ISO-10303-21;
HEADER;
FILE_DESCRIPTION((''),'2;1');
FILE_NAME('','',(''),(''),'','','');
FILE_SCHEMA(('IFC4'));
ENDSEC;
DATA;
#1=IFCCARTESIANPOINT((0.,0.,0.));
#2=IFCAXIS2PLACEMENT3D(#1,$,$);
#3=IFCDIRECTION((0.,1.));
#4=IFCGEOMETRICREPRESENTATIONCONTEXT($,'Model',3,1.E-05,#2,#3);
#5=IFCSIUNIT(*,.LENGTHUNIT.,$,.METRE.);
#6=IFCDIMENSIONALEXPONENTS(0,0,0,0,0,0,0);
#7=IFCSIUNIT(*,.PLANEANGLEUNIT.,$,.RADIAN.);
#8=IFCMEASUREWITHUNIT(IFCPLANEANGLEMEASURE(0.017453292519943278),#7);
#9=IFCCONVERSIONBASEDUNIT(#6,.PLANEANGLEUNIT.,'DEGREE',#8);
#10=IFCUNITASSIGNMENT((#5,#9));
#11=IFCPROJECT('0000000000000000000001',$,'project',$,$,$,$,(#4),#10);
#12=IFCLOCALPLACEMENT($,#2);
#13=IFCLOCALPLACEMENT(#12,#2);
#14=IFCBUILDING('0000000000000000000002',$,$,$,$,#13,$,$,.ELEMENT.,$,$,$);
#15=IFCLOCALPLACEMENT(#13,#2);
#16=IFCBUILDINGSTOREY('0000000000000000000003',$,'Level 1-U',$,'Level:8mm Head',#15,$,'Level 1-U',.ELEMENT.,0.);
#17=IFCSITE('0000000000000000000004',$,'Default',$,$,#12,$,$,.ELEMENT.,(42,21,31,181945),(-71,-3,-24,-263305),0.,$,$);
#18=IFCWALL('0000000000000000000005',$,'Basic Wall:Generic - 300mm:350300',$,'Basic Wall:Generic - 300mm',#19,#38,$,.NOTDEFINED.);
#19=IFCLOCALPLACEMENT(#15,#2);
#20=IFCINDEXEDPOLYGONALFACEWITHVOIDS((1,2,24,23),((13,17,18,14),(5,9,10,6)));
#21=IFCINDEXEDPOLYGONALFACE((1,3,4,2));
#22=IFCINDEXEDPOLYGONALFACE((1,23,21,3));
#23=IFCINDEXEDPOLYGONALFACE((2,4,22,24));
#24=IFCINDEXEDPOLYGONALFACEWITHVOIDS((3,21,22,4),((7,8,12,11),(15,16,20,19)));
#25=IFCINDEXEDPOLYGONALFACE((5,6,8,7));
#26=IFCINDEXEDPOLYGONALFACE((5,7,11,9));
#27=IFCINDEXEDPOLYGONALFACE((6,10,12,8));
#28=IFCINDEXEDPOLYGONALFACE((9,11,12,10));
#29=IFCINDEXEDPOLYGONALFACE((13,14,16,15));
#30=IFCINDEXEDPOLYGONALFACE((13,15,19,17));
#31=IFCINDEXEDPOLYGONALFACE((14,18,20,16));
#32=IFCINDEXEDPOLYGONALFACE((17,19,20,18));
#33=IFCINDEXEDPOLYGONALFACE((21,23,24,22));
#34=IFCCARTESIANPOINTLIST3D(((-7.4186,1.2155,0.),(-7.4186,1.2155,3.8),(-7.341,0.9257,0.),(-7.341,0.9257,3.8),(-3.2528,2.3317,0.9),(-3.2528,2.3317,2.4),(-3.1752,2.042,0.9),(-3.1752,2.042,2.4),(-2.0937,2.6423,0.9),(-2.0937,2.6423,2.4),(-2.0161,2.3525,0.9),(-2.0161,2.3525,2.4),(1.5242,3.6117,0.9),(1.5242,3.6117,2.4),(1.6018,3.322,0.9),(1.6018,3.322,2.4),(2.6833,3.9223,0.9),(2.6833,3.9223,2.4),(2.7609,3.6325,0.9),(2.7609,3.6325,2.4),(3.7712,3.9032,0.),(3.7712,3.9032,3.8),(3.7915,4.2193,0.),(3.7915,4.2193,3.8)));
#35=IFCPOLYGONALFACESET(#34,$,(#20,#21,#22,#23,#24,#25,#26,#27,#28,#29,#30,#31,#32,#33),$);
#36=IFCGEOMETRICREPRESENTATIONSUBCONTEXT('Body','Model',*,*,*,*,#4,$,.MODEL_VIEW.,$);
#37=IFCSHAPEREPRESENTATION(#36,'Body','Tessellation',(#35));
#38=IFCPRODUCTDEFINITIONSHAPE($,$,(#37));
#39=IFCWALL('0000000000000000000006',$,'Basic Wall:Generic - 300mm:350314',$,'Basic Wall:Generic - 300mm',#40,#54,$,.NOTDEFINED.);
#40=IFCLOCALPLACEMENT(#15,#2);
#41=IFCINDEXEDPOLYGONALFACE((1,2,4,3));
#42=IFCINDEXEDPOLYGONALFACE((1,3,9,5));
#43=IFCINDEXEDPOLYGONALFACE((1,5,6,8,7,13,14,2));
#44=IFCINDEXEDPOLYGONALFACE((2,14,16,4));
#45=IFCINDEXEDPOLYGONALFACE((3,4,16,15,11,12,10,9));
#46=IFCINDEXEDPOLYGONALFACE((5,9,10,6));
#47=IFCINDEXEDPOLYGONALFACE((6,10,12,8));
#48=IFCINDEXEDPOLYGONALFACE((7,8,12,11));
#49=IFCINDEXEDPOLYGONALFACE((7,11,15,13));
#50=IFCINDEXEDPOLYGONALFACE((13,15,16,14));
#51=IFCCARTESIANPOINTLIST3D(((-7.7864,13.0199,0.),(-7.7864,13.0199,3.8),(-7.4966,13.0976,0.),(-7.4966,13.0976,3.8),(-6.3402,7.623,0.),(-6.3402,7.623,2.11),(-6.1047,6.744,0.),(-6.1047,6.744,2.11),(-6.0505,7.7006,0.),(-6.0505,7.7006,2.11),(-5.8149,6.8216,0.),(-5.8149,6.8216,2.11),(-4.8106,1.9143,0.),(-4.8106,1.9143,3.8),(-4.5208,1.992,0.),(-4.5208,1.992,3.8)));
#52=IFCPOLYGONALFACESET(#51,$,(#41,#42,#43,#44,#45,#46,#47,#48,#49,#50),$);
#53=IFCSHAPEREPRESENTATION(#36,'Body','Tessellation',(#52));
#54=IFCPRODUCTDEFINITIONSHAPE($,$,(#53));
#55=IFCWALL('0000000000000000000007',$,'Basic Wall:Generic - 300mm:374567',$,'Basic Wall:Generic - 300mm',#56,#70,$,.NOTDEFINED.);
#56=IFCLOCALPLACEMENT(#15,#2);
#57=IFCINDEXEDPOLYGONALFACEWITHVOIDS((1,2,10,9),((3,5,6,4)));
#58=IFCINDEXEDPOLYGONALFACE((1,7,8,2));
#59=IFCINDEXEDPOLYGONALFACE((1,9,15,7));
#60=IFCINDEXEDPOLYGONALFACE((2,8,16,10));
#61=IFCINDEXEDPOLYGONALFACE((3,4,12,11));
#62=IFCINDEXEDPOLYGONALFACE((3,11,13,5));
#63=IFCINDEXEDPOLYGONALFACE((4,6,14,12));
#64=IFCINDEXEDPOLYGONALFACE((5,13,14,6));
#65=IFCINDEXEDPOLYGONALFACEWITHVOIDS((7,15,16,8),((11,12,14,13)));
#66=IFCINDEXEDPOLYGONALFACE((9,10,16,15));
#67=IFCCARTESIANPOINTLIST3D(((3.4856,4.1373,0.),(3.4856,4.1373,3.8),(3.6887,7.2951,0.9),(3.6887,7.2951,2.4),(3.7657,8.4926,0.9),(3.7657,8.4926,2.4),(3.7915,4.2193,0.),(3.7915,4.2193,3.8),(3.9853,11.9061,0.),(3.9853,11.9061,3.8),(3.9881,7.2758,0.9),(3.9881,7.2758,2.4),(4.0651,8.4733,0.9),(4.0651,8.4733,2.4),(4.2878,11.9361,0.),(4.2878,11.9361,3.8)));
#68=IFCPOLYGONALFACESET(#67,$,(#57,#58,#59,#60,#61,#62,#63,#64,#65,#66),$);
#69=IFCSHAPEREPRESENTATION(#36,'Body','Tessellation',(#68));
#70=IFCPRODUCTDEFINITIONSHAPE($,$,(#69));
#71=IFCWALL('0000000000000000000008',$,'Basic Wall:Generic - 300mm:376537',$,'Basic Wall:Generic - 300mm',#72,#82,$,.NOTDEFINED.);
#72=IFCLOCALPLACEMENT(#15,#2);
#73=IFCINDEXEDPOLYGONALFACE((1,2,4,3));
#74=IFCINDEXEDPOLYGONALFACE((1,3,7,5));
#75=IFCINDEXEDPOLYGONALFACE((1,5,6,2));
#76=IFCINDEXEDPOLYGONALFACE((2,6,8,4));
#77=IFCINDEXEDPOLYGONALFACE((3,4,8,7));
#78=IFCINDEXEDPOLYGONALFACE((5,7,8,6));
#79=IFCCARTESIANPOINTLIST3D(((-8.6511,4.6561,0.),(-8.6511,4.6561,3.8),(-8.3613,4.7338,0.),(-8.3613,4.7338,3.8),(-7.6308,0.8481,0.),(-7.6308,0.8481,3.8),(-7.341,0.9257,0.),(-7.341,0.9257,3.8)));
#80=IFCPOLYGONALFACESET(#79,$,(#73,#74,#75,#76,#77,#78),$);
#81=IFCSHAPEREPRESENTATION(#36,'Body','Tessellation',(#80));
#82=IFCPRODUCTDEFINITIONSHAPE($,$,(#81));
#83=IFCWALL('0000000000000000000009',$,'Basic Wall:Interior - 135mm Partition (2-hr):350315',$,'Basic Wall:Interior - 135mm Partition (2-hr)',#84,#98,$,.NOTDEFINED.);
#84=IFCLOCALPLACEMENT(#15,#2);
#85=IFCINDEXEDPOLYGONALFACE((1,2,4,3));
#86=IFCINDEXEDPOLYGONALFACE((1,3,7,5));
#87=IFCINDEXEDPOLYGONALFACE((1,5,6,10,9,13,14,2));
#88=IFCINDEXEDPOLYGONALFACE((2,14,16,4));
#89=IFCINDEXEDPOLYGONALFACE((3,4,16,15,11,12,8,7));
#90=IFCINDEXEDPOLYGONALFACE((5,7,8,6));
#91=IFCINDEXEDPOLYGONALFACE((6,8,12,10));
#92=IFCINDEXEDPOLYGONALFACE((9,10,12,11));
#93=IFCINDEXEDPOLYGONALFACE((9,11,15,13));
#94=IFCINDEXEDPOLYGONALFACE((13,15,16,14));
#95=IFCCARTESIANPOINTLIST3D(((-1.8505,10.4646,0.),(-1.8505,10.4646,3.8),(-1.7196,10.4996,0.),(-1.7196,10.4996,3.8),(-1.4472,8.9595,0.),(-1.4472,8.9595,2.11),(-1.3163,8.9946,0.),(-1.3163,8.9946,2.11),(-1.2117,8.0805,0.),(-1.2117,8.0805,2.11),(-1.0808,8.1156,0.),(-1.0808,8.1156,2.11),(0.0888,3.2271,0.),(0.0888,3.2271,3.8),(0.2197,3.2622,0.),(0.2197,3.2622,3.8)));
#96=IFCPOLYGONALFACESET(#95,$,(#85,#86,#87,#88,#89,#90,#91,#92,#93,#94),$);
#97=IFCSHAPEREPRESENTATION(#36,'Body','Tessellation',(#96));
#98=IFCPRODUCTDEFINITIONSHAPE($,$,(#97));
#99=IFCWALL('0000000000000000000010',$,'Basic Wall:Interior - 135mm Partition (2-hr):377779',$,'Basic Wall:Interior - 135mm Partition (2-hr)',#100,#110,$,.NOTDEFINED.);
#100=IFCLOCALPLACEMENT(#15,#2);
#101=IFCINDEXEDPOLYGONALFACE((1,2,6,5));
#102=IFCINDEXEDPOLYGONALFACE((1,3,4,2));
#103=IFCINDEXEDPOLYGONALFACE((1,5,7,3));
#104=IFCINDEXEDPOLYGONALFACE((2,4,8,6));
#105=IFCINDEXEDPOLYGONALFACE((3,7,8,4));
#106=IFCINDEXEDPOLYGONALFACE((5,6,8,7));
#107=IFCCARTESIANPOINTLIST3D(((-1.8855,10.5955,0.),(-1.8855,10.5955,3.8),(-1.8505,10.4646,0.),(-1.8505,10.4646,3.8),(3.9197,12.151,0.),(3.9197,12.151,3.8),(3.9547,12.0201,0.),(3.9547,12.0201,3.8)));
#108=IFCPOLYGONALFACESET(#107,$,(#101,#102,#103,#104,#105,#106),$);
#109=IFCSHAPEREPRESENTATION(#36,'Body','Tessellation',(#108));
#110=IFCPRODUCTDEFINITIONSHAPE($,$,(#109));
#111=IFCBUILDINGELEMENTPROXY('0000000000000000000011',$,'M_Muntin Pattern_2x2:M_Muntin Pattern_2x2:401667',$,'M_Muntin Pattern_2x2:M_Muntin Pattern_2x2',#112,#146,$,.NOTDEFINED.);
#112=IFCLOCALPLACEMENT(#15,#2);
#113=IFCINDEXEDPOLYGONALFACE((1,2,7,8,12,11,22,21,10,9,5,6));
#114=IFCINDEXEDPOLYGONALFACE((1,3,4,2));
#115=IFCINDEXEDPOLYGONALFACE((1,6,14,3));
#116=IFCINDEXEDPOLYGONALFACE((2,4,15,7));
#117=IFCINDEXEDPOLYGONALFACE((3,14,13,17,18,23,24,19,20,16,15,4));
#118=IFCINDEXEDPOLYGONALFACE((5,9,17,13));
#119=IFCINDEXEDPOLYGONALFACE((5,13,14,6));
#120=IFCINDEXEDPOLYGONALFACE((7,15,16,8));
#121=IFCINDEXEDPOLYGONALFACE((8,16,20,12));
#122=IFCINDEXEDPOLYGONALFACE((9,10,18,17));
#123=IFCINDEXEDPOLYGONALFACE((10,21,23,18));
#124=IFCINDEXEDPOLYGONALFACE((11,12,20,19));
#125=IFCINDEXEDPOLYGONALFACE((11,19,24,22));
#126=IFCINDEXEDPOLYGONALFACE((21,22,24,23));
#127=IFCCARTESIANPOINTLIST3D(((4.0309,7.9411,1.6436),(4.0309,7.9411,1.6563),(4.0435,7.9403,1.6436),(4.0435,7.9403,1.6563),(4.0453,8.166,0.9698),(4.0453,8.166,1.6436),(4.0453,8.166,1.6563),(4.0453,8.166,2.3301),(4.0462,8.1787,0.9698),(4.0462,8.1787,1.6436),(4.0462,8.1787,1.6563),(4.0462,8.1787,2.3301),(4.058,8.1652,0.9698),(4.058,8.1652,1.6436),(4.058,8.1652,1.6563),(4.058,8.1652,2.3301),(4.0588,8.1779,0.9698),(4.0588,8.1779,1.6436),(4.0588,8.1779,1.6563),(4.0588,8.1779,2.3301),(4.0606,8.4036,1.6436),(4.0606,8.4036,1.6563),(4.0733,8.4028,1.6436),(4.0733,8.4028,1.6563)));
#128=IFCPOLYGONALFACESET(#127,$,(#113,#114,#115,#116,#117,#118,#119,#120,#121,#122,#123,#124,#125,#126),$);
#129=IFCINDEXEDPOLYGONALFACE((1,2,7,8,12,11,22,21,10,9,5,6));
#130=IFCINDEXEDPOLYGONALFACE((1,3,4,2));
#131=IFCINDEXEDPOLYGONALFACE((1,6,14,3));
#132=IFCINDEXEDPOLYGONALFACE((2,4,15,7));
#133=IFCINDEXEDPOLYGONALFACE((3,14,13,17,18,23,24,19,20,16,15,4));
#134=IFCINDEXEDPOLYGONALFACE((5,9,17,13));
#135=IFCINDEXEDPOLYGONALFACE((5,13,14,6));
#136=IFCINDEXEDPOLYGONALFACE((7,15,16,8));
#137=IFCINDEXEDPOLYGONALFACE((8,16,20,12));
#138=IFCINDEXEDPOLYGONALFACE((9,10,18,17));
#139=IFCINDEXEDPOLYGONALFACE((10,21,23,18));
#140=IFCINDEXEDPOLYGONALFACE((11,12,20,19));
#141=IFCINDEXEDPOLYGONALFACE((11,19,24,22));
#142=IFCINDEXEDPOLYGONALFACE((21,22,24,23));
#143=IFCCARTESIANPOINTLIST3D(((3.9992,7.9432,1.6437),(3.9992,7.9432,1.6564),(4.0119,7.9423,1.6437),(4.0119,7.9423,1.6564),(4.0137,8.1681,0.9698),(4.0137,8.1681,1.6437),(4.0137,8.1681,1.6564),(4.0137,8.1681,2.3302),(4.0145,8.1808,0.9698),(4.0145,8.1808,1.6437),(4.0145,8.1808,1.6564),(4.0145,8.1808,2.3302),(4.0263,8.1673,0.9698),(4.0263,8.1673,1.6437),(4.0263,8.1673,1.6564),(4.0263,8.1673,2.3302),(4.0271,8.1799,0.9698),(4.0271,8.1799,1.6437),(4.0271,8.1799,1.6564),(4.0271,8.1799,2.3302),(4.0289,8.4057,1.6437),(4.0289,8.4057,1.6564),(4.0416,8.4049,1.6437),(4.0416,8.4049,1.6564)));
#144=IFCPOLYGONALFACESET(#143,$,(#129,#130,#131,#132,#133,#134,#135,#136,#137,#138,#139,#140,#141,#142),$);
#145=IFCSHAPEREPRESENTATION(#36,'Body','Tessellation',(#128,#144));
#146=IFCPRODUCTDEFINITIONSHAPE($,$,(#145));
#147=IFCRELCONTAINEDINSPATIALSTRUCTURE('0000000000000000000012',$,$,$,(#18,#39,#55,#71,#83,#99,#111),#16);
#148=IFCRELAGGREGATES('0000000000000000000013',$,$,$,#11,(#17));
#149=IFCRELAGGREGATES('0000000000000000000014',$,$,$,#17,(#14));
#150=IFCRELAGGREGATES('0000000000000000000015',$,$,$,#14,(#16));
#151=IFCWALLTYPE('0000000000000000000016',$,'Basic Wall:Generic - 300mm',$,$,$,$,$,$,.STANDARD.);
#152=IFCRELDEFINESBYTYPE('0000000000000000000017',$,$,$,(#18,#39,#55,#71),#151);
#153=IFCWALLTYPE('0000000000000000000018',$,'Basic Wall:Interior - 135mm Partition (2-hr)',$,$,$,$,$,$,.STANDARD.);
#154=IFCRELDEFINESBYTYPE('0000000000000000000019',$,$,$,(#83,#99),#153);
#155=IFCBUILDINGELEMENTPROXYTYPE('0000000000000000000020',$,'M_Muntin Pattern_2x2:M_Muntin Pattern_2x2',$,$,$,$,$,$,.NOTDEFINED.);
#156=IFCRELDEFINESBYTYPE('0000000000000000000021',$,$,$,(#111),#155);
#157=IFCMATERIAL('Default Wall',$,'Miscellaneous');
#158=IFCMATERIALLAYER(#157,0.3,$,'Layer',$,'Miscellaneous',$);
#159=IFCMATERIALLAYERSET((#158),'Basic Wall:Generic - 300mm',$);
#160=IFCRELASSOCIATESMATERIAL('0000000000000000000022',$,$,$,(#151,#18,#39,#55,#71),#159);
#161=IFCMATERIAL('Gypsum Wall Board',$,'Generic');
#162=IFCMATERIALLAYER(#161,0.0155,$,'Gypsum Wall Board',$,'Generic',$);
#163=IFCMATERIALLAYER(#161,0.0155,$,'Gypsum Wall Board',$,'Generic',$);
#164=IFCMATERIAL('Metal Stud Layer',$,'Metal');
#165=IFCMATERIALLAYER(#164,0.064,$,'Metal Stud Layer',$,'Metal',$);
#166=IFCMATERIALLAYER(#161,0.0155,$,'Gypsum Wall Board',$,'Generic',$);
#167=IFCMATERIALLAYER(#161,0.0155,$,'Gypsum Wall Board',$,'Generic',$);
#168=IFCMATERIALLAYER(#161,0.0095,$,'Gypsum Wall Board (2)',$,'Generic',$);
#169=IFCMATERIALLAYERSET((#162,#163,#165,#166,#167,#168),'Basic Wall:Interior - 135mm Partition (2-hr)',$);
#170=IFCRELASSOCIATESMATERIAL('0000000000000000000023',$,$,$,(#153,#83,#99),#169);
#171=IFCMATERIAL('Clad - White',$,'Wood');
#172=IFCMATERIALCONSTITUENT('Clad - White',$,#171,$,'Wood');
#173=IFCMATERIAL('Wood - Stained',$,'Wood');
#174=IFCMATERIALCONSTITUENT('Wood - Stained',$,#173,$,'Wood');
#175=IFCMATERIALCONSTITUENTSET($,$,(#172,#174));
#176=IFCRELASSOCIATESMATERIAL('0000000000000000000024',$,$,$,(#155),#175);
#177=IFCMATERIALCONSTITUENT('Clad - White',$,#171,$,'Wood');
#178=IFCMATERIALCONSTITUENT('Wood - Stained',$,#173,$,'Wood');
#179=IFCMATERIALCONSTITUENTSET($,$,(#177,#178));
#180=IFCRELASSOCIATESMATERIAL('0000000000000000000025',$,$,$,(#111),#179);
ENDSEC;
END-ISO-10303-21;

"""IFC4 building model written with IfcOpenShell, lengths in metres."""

from ifc_helpers import new_model, entity, si_unit, converted_unit, direction, frame, frame_2d, origin, place, context, subcontext, project, spatial, polyline, rectangle, outline, extrude, source, transform, mapped, material, layer, layer_set, layer_usage, constituent, constituent_set, type_object, type_shapes, element, save


model = new_model("IFC4")

# Units and contexts
model_context = context("Model", 3, precision=1e-05, world=origin(), true_north=direction((0.0, 1.0)))
body_context = subcontext(model_context, "Body", "Model", "MODEL_VIEW")
ifc_project = project(units=[si_unit("LENGTHUNIT", "METRE"), converted_unit("PLANEANGLEUNIT", "DEGREE", entity("IfcPlaneAngleMeasure", 0.017453292519943278), si_unit("PLANEANGLEUNIT", "RADIAN"), dimensions=[0, 0, 0, 0, 0, 0, 0])], contexts=[model_context])

# Site, building, storey
site_placement = place(None, origin())
site = spatial("IfcSite", under=ifc_project, at=site_placement, Name="Default", CompositionType="ELEMENT", RefLatitude=(42, 21, 31, 181945), RefLongitude=(-71, -3, -24, -263305), RefElevation=0.0)
building_placement = place(site_placement, origin())
building = spatial("IfcBuilding", under=site, at=building_placement, CompositionType="ELEMENT")
storey_placement = place(building_placement, origin())
storey = spatial("IfcBuildingStorey", under=building, at=storey_placement, Name="Level 1-U", ObjectType="Level:8mm Head", LongName="Level 1-U", CompositionType="ELEMENT", Elevation=0.0)

# Wall, openings
ifc_material_1 = material(Name="Default Wall", Category="Miscellaneous")
ifc_layer_1 = layer(ifc_material_1, 0.3, Name="Layer", Category="Miscellaneous")
ifc_layer_set_1 = layer_set([ifc_layer_1], Name="Basic Wall:Generic - 300mm")
ifc_layer_usage_1 = layer_usage(ifc_layer_set_1, "AXIS2", "NEGATIVE", 0.15)
wall_type_1 = type_object("IfcWallType", Name="Basic Wall:Generic - 300mm", PredefinedType="STANDARD", material=ifc_layer_set_1)
wall_1_placement = place(storey_placement, frame((3.8303, 4.0744, 0.0), z_axis=(0.0, 0.0, 1.0), x_axis=(-0.965926, -0.258819, 0.0)))
wall_1 = element("IfcWall", 1, at=wall_1_placement, inside=storey, type_object=wall_type_1, material=ifc_layer_usage_1, Name="Basic Wall:Generic - 300mm:350300", ObjectType="Basic Wall:Generic - 300mm", PredefinedType="NOTDEFINED", context=body_context, shape_type="SweptSolid", body=[
    extrude(outline(polyline([(11.6056, -0.15), (11.6056, 0.15), (0.1014, 0.15), (0.0, -0.15), (0.3167, -0.15), (8.6056, -0.15), (8.9056, -0.15), (11.6056, -0.15)])), origin(), (0.0, 0.0, 1.0), 3.8),
])
opening_1_placement = place(wall_1_placement, frame((6.0928, -0.15, 0.9)))
element("IfcOpeningElement", 2, at=opening_1_placement, cuts=wall_1, PredefinedType="OPENING", context=body_context, shape_type="SweptSolid", body=[
    extrude(rectangle(XDim=1.5, YDim=1.2, at=frame_2d((0.75, 0.6), x_axis=(-1.0, 0.0))), frame((0.0, 0.0, 0.0), z_axis=(0.0, 1.0, 0.0), x_axis=(0.0, 0.0, 1.0)), (0.0, 0.0, 1.0), 0.3),
])
opening_2_placement = place(wall_1_placement, frame((1.1473, -0.15, 0.9)))
element("IfcOpeningElement", 3, at=opening_2_placement, cuts=wall_1, PredefinedType="OPENING", context=body_context, shape_type="SweptSolid", body=[
    extrude(rectangle(XDim=1.5, YDim=1.2, at=frame_2d((0.75, 0.6), x_axis=(-1.0, 0.0))), frame((0.0, 0.0, 0.0), z_axis=(0.0, 1.0, 0.0), x_axis=(0.0, 0.0, 1.0)), (0.0, 0.0, 1.0), 0.3),
])

# Walls, openings
wall_2_placement = place(storey_placement, frame((-7.6415, 13.0588, 0.0), z_axis=(0.0, 0.0, 1.0), x_axis=(0.258819, -0.965926, 0.0)))
wall_2 = element("IfcWall", 4, at=wall_2_placement, inside=storey, type_object=wall_type_1, material=ifc_layer_usage_1, Name="Basic Wall:Generic - 300mm:350314", ObjectType="Basic Wall:Generic - 300mm", PredefinedType="NOTDEFINED", context=body_context, shape_type="SweptSolid", body=[
    extrude(rectangle(XDim=11.4974, YDim=0.3, at=frame_2d((5.7487, 0.0), x_axis=(1.0, 0.0))), origin(), (0.0, 0.0, 1.0), 3.8),
])
opening_3_placement = place(wall_2_placement, frame((5.5874, -0.15, 0.0)))
element("IfcOpeningElement", 5, at=opening_3_placement, cuts=wall_2, PredefinedType="OPENING", context=body_context, shape_type="SweptSolid", body=[
    extrude(rectangle(XDim=2.11, YDim=0.91, at=frame_2d((1.055, 0.455), x_axis=(1.0, 0.0))), frame((0.0, 0.0, 0.0), z_axis=(0.0, 1.0, 0.0), x_axis=(0.0, 0.0, 1.0)), (0.0, 0.0, 1.0), 0.3),
])
wall_3_placement = place(storey_placement, frame((4.1381, 11.9457, 0.0), z_axis=(0.0, 0.0, 1.0), x_axis=(-0.064186, -0.997938, 0.0)))
wall_3 = element("IfcWall", 6, at=wall_3_placement, inside=storey, type_object=wall_type_1, material=ifc_layer_usage_1, Name="Basic Wall:Generic - 300mm:374567", ObjectType="Basic Wall:Generic - 300mm", PredefinedType="NOTDEFINED", context=body_context, shape_type="SweptSolid", body=[
    extrude(outline(polyline([(7.8342, -0.15), (7.7328, 0.15), (0.0, 0.15), (0.0493, -0.15), (7.8342, -0.15)])), origin(), (0.0, 0.0, 1.0), 3.8),
])
opening_4_placement = place(wall_3_placement, frame((3.4699, -0.15, 0.9)))
element("IfcOpeningElement", 7, at=opening_4_placement, cuts=wall_3, PredefinedType="OPENING", context=body_context, shape_type="SweptSolid", body=[
    extrude(rectangle(XDim=1.5, YDim=1.2, at=frame_2d((0.75, 0.6), x_axis=(-1.0, 0.0))), frame((0.0, 0.0, 0.0), z_axis=(0.0, 1.0, 0.0), x_axis=(0.0, 0.0, 1.0)), (0.0, 0.0, 1.0), 0.3),
])

# Wall
wall_4_placement = place(storey_placement, frame((-8.5062, 4.6949, 0.0), z_axis=(0.0, 0.0, 1.0), x_axis=(0.258819, -0.965926, 0.0)))
element("IfcWall", 8, at=wall_4_placement, inside=storey, type_object=wall_type_1, material=ifc_layer_usage_1, Name="Basic Wall:Generic - 300mm:376537", ObjectType="Basic Wall:Generic - 300mm", PredefinedType="NOTDEFINED", context=body_context, shape_type="SweptSolid", body=[
    extrude(rectangle(XDim=3.9424, YDim=0.3, at=frame_2d((1.9712, 0.0), x_axis=(-1.0, 0.0))), origin(), (0.0, 0.0, 1.0), 3.8),
])

# Wall, opening
ifc_material_2 = material(Name="Gypsum Wall Board", Category="Generic")
ifc_layer_2 = layer(ifc_material_2, 0.0155, Name="Gypsum Wall Board", Category="Generic")
ifc_layer_3 = layer(ifc_material_2, 0.0155, Name="Gypsum Wall Board", Category="Generic")
ifc_material_3 = material(Name="Metal Stud Layer", Category="Metal")
ifc_layer_4 = layer(ifc_material_3, 0.064, Name="Metal Stud Layer", Category="Metal")
ifc_layer_5 = layer(ifc_material_2, 0.0155, Name="Gypsum Wall Board", Category="Generic")
ifc_layer_6 = layer(ifc_material_2, 0.0155, Name="Gypsum Wall Board", Category="Generic")
ifc_layer_7 = layer(ifc_material_2, 0.0095, Name="Gypsum Wall Board (2)", Category="Generic")
ifc_layer_set_2 = layer_set([ifc_layer_2, ifc_layer_3, ifc_layer_4, ifc_layer_5, ifc_layer_6, ifc_layer_7], Name="Basic Wall:Interior - 135mm Partition (2-hr)")
ifc_layer_usage_2 = layer_usage(ifc_layer_set_2, "AXIS2", "NEGATIVE", 0.0677)
wall_type_2 = type_object("IfcWallType", Name="Basic Wall:Interior - 135mm Partition (2-hr)", PredefinedType="STANDARD", material=ifc_layer_set_2)
wall_5_placement = place(storey_placement, frame((-1.785, 10.4821, 0.0), z_axis=(0.0, 0.0, 1.0), x_axis=(0.258819, -0.965926, 0.0)))
wall_5 = element("IfcWall", 9, at=wall_5_placement, inside=storey, type_object=wall_type_2, material=ifc_layer_usage_2, Name="Basic Wall:Interior - 135mm Partition (2-hr):350315", ObjectType="Basic Wall:Interior - 135mm Partition (2-hr)", PredefinedType="NOTDEFINED", context=body_context, shape_type="SweptSolid", body=[
    extrude(rectangle(XDim=7.4928, YDim=0.1355, at=frame_2d((3.7464, 0.0), x_axis=(-1.0, 0.0))), origin(), (0.0, 0.0, 1.0), 3.8),
])
opening_5_placement = place(wall_5_placement, frame((2.4681, 0.0677, 0.0)))
element("IfcOpeningElement", 10, at=opening_5_placement, cuts=wall_5, PredefinedType="OPENING", context=body_context, shape_type="SweptSolid", body=[
    extrude(rectangle(XDim=2.11, YDim=0.91, at=frame_2d((1.055, 0.455), x_axis=(1.0, 0.0))), frame((0.0, 0.0, 0.0), z_axis=(0.0, -1.0, 0.0), x_axis=(0.0, 0.0, 1.0)), (0.0, 0.0, 1.0), 0.1355),
])

# Wall
wall_6_placement = place(storey_placement, frame((-1.868, 10.53, 0.0), z_axis=(0.0, 0.0, 1.0), x_axis=(0.965926, 0.258819, 0.0)))
element("IfcWall", 11, at=wall_6_placement, inside=storey, type_object=wall_type_2, material=ifc_layer_usage_2, Name="Basic Wall:Interior - 135mm Partition (2-hr):377779", ObjectType="Basic Wall:Interior - 135mm Partition (2-hr)", PredefinedType="NOTDEFINED", context=body_context, shape_type="SweptSolid", body=[
    extrude(rectangle(XDim=6.01, YDim=0.1355, at=frame_2d((3.005, 0.0), x_axis=(-1.0, 0.0))), origin(), (0.0, 0.0, 1.0), 3.8),
])

# Building element proxy
ifc_material_4 = material(Name="Clad - White", Category="Wood")
ifc_constituent_1 = constituent(ifc_material_4, Name="Clad - White", Category="Wood")
ifc_material_5 = material(Name="Wood - Stained", Category="Wood")
ifc_constituent_2 = constituent(ifc_material_5, Name="Wood - Stained", Category="Wood")
ifc_constituent_set_1 = constituent_set(constituents=[ifc_constituent_1, ifc_constituent_2])
ifc_constituent_3 = constituent(ifc_material_4, Name="Clad - White", Category="Wood")
ifc_constituent_4 = constituent(ifc_material_5, Name="Wood - Stained", Category="Wood")
ifc_constituent_set_2 = constituent_set(constituents=[ifc_constituent_3, ifc_constituent_4])
building_element_proxy_type_1 = type_object("IfcBuildingElementProxyType", Name="M_Muntin Pattern_2x2:M_Muntin Pattern_2x2", PredefinedType="NOTDEFINED", material=ifc_constituent_set_2)
shared_shape_1 = source(origin(), body_context, "Body", "SweptSolid", [
    extrude(outline(polyline([(0.0064, -0.0064), (0.6801, -0.0064), (0.6801, 0.0063), (0.0064, 0.0063), (0.0064, 0.2317), (-0.0063, 0.2317), (-0.0063, 0.0063), (-0.6802, 0.0063), (-0.6802, -0.0064), (-0.0063, -0.0064), (-0.0063, -0.2317), (0.0064, -0.2317), (0.0064, -0.0064)])), frame((0.0, 0.0095, 0.6801), z_axis=(0.0, 1.0, 0.0), x_axis=(0.0, 0.0, 1.0)), (0.0, 0.0, 1.0), 0.0127),
    extrude(outline(polyline([(0.0064, -0.0064), (0.6802, -0.0064), (0.6802, 0.0063), (0.0064, 0.0063), (0.0064, 0.2317), (-0.0063, 0.2317), (-0.0063, 0.0063), (-0.6802, 0.0063), (-0.6802, -0.0064), (-0.0063, -0.0064), (-0.0063, -0.2317), (0.0064, -0.2317), (0.0064, -0.0064)])), frame((0.0, -0.0222, 0.6802), z_axis=(0.0, 1.0, 0.0), x_axis=(0.0, 0.0, 1.0)), (0.0, 0.0, 1.0), 0.0127),
])
type_shapes(building_element_proxy_type_1, [shared_shape_1])
proxy_1_placement = place(storey_placement, frame((4.0362, 8.173, 0.9698), z_axis=(0.0, 0.0, 1.0), x_axis=(-0.064186, -0.997938, 0.0)))
element("IfcBuildingElementProxy", 12, at=proxy_1_placement, inside=storey, type_object=building_element_proxy_type_1, material=ifc_constituent_set_1, Name="M_Muntin Pattern_2x2:M_Muntin Pattern_2x2:401667", ObjectType="M_Muntin Pattern_2x2:M_Muntin Pattern_2x2", PredefinedType="NOTDEFINED", context=body_context, shape_type="MappedRepresentation", body=[
    mapped(shared_shape_1, transform((0.0, 0.0, 0.0), scale=1.0)),
])

save(model, "model.ifc")
